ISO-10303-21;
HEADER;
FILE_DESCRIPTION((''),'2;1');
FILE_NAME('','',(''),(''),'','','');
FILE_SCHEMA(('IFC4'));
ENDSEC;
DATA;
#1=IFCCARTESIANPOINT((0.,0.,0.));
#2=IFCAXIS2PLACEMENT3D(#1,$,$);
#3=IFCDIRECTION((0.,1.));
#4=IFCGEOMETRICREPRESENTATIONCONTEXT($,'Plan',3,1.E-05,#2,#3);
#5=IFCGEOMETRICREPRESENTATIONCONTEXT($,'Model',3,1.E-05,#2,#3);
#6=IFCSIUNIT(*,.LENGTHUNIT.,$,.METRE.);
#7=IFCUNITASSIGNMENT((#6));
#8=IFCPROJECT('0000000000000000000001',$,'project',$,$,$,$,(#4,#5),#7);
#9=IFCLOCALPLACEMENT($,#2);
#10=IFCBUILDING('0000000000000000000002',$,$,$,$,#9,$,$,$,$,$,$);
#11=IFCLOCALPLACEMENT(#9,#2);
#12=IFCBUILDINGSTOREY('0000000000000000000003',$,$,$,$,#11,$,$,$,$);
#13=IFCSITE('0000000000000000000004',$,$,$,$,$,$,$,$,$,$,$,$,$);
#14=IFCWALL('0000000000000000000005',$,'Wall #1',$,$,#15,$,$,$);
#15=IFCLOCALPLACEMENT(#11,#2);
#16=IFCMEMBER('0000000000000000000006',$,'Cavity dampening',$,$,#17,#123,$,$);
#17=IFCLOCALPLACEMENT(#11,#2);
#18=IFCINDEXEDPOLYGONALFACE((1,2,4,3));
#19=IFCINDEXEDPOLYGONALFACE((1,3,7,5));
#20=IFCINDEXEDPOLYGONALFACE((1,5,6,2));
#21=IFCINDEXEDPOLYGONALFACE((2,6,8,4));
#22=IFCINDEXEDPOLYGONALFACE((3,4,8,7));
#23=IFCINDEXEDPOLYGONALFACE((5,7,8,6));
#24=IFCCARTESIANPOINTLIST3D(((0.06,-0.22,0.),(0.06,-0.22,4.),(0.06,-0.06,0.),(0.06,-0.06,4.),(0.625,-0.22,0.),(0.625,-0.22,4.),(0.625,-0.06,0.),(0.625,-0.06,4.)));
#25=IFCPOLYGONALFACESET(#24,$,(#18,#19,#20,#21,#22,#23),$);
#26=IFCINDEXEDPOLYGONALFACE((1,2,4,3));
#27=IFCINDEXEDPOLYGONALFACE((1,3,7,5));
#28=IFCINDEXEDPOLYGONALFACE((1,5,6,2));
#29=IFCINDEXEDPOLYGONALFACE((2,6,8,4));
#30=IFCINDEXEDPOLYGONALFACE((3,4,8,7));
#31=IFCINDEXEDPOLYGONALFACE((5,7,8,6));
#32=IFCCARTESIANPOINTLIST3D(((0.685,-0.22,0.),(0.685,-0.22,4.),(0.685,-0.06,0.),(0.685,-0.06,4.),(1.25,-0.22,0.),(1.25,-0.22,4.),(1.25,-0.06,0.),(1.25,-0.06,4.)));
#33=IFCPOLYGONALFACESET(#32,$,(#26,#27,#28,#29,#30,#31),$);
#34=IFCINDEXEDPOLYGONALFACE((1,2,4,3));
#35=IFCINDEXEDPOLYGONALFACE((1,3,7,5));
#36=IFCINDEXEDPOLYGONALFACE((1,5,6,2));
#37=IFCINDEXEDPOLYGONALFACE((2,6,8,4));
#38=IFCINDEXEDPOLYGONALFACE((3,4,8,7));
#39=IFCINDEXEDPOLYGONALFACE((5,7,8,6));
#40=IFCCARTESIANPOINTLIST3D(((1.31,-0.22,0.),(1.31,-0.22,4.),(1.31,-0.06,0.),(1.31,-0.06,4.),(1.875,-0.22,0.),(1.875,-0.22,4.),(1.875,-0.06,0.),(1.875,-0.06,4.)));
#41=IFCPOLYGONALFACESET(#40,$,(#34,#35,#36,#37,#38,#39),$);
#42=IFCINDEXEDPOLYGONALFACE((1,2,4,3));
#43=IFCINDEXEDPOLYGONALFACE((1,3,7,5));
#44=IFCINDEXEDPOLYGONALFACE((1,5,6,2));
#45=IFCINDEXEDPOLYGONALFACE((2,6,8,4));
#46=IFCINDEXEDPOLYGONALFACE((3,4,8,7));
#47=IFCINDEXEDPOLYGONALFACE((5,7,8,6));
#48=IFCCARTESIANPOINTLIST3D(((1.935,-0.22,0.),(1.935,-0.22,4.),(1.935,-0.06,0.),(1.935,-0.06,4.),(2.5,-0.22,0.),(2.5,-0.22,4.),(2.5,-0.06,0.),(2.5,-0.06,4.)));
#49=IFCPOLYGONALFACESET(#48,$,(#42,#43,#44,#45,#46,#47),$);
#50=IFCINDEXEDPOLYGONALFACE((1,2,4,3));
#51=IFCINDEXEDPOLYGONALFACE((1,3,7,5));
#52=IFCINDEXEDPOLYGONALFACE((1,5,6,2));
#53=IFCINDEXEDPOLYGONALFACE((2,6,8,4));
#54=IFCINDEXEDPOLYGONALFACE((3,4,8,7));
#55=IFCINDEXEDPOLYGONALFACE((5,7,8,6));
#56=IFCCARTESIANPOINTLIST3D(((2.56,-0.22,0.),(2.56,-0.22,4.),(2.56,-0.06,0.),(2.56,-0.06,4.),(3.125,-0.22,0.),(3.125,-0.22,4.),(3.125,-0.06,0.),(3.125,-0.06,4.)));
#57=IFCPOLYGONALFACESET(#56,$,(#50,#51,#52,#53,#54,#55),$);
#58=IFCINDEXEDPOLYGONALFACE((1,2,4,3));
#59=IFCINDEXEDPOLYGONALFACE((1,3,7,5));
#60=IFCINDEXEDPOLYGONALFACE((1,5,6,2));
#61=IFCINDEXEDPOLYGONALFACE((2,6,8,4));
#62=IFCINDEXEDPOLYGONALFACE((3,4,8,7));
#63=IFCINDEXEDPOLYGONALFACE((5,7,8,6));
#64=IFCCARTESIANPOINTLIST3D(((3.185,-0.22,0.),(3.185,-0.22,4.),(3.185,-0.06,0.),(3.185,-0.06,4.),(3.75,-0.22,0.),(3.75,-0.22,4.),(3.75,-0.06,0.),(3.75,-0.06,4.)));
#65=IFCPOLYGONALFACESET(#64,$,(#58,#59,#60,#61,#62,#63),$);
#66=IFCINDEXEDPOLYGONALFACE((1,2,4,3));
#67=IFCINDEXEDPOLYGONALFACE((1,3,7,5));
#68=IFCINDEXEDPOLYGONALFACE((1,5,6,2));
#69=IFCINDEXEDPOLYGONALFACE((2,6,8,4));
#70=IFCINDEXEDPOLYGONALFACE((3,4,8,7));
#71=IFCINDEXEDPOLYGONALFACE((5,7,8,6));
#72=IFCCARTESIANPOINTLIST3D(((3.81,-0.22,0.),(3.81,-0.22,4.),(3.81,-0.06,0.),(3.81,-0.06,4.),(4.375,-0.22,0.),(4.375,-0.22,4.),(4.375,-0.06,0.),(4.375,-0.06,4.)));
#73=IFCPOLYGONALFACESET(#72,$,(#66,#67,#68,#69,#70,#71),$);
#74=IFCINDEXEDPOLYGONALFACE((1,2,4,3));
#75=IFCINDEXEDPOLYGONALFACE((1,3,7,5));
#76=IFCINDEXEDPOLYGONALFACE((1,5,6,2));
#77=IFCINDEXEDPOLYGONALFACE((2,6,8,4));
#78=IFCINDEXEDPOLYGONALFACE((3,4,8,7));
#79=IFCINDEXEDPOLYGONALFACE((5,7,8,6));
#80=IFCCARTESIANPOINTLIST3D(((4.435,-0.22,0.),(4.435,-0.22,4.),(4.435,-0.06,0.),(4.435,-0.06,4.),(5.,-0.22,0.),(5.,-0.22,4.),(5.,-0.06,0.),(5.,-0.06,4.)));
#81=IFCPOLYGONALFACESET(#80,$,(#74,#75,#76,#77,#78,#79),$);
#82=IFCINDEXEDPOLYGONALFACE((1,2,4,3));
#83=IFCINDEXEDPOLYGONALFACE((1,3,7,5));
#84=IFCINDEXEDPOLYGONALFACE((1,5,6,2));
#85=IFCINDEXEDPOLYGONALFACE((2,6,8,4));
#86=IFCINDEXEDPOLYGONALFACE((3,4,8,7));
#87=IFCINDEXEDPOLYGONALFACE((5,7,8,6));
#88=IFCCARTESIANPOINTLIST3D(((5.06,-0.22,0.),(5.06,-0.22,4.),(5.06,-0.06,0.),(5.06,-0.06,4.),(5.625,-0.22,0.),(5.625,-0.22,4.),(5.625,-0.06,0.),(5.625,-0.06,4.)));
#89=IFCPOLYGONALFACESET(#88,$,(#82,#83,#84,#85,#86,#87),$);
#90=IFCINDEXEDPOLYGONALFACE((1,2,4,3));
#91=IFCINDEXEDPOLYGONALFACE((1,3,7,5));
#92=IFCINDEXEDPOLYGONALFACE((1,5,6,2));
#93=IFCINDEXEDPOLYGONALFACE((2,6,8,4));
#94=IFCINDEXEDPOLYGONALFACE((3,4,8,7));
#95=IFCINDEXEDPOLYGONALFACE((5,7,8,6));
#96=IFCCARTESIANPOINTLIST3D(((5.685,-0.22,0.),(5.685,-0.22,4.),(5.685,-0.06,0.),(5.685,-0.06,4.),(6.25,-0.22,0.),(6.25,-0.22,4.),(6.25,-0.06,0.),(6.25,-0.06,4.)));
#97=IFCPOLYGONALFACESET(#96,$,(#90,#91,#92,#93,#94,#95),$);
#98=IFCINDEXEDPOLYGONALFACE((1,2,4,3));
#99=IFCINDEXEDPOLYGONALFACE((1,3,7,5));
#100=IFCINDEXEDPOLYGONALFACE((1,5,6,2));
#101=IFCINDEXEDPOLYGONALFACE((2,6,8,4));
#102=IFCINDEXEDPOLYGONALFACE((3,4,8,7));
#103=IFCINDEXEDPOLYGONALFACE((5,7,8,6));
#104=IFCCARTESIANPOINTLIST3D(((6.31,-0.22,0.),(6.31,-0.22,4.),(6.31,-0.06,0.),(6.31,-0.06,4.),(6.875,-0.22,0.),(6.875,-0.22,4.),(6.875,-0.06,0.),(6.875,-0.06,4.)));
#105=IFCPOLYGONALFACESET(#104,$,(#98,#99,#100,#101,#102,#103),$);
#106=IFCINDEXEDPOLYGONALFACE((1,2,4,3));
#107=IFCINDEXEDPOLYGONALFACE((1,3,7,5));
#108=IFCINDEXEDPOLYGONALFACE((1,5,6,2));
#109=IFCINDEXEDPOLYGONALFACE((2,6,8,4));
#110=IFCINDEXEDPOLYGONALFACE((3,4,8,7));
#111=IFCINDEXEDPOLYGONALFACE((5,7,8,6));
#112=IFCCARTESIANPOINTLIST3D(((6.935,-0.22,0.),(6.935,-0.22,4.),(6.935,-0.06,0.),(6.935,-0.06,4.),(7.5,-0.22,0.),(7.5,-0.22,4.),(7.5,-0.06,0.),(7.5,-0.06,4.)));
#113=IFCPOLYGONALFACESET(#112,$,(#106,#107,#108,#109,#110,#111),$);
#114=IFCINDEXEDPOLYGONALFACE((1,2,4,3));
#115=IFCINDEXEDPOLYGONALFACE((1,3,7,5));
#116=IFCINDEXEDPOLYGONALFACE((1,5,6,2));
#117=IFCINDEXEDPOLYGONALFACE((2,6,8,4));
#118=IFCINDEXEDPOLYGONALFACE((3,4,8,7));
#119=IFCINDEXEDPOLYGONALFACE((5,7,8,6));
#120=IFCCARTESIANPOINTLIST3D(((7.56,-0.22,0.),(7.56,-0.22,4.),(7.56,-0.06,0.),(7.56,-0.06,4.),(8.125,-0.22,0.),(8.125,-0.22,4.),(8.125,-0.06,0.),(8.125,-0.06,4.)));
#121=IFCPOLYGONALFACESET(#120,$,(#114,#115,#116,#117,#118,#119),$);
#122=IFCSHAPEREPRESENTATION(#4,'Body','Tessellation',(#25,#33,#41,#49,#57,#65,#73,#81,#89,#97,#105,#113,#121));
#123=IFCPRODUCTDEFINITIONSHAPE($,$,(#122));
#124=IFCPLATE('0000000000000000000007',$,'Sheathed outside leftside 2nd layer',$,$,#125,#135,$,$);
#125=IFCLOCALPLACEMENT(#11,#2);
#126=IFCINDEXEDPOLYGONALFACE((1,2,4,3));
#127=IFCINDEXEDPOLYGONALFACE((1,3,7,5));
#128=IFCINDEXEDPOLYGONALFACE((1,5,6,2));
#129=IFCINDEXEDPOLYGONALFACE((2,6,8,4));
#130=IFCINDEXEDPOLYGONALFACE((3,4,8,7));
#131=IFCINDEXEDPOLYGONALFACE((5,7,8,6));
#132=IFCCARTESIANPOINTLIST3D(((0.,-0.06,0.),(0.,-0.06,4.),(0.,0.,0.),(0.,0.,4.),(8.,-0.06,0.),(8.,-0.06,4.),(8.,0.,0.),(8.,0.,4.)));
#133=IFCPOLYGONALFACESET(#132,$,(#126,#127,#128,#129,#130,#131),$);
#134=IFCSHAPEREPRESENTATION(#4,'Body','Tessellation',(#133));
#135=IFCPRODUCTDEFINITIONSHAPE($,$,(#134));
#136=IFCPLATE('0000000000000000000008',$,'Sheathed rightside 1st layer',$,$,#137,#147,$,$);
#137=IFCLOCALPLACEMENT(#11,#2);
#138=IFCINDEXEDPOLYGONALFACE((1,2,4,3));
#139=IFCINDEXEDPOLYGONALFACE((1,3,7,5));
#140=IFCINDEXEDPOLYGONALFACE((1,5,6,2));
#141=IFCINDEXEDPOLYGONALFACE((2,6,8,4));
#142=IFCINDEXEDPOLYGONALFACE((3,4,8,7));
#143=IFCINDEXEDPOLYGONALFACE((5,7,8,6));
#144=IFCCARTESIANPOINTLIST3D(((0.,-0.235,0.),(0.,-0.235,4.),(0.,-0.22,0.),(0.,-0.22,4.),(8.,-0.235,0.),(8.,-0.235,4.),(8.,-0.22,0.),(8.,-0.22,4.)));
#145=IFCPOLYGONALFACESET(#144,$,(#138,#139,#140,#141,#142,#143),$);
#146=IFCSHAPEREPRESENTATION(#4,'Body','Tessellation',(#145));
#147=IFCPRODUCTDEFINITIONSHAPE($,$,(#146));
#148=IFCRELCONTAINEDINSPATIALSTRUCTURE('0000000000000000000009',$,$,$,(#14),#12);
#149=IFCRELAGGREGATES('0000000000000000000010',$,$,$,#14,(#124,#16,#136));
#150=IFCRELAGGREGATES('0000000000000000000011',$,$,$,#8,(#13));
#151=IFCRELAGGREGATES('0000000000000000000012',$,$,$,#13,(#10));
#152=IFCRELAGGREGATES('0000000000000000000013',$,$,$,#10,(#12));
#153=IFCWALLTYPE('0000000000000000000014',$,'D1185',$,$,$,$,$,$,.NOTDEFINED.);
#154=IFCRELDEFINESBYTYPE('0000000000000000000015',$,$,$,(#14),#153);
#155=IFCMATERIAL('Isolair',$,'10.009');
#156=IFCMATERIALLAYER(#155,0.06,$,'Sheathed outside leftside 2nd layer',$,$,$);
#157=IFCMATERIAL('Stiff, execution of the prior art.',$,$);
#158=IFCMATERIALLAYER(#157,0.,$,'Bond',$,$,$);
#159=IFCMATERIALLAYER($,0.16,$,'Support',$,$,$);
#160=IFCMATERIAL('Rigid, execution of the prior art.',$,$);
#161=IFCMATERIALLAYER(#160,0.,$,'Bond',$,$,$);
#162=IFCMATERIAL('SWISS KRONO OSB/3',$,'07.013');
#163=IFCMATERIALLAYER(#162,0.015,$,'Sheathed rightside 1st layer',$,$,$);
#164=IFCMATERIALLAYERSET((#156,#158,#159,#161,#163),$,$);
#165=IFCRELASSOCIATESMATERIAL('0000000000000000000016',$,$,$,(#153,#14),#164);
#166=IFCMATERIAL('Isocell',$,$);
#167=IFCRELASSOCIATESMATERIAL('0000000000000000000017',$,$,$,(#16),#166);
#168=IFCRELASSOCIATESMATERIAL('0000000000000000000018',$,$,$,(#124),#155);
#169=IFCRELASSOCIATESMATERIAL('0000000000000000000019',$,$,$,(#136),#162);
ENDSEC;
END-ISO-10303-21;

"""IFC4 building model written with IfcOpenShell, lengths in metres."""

from ifc_helpers import new_model, si_unit, direction, frame, frame_2d, origin, origin_with_axes, place, context, project, spatial, rectangle, extrude, material, layer, layer_set, type_object, element, aggregate, save


model = new_model("IFC4")

# Units and contexts
plan_context = context("Plan", 3, precision=1e-05, world=origin(), true_north=direction((0.0, 1.0)))
model_context = context("Model", 3, precision=1e-05, world=origin(), true_north=direction((0.0, 1.0)))
ifc_project = project(units=[si_unit("LENGTHUNIT", "METRE")], contexts=[plan_context, model_context])

# Site, building, storey
site = spatial("IfcSite", under=ifc_project)
building_placement = place(None, origin())
building = spatial("IfcBuilding", under=site, at=building_placement)
storey_placement = place(building_placement, origin())
storey = spatial("IfcBuildingStorey", under=building, at=storey_placement)

# Wall, member, plates
ifc_material_1 = material(Name="Isolair", Category="10.009")
ifc_layer_1 = layer(ifc_material_1, 0.06, Name="Sheathed outside leftside 2nd layer")
ifc_material_2 = material(Name="Stiff, execution of the prior art.")
ifc_layer_2 = layer(ifc_material_2, 0.0, Name="Bond")
ifc_layer_3 = layer(None, 0.16, Name="Support")
ifc_material_3 = material(Name="Rigid, execution of the prior art.")
ifc_layer_4 = layer(ifc_material_3, 0.0, Name="Bond")
ifc_material_4 = material(Name="SWISS KRONO OSB/3", Category="07.013")
ifc_layer_5 = layer(ifc_material_4, 0.015, Name="Sheathed rightside 1st layer")
ifc_layer_set = layer_set([ifc_layer_1, ifc_layer_2, ifc_layer_3, ifc_layer_4, ifc_layer_5])
wall_type = type_object("IfcWallType", Name="D1185", PredefinedType="NOTDEFINED", material=ifc_layer_set)
wall_placement = place(None, frame((0.0, 0.0, 0.0), z_axis=(0.0, -1.0, 0.0), x_axis=(1.0, 0.0, 0.0)))
wall = element("IfcWall", 1, at=wall_placement, inside=storey, type_object=wall_type, material=ifc_layer_set, Name="Wall #1")
ifc_material_5 = material(Name="Isocell")
member_1_placement = place(wall_placement, origin())
member_1 = element("IfcMember", 2, at=member_1_placement, material=ifc_material_5, Name="Cavity dampening", context=plan_context, shape_type="SweptSolid", body=[
    extrude(rectangle(XDim=0.565, YDim=0.16, at=frame_2d((0.2825, 0.08), x_axis=(1.0, 0.0))), frame((0.06, 4.0, 0.06), z_axis=(0.0, -1.0, 0.0), x_axis=(1.0, 0.0, 0.0)), (0.0, 0.0, 1.0), 4.0),
    extrude(rectangle(XDim=0.565, YDim=0.16, at=frame_2d((0.2825, 0.08), x_axis=(1.0, 0.0))), frame((0.685, 4.0, 0.06), z_axis=(0.0, -1.0, 0.0), x_axis=(1.0, 0.0, 0.0)), (0.0, 0.0, 1.0), 4.0),
    extrude(rectangle(XDim=0.565, YDim=0.16, at=frame_2d((0.2825, 0.08), x_axis=(1.0, 0.0))), frame((1.31, 4.0, 0.06), z_axis=(0.0, -1.0, 0.0), x_axis=(1.0, 0.0, 0.0)), (0.0, 0.0, 1.0), 4.0),
    extrude(rectangle(XDim=0.565, YDim=0.16, at=frame_2d((0.2825, 0.08), x_axis=(1.0, 0.0))), frame((1.935, 4.0, 0.06), z_axis=(0.0, -1.0, 0.0), x_axis=(1.0, 0.0, 0.0)), (0.0, 0.0, 1.0), 4.0),
    extrude(rectangle(XDim=0.565, YDim=0.16, at=frame_2d((0.2825, 0.08), x_axis=(1.0, 0.0))), frame((2.56, 4.0, 0.06), z_axis=(0.0, -1.0, 0.0), x_axis=(1.0, 0.0, 0.0)), (0.0, 0.0, 1.0), 4.0),
    extrude(rectangle(XDim=0.565, YDim=0.16, at=frame_2d((0.2825, 0.08), x_axis=(1.0, 0.0))), frame((3.185, 4.0, 0.06), z_axis=(0.0, -1.0, 0.0), x_axis=(1.0, 0.0, 0.0)), (0.0, 0.0, 1.0), 4.0),
    extrude(rectangle(XDim=0.565, YDim=0.16, at=frame_2d((0.2825, 0.08), x_axis=(1.0, 0.0))), frame((3.81, 4.0, 0.06), z_axis=(0.0, -1.0, 0.0), x_axis=(1.0, 0.0, 0.0)), (0.0, 0.0, 1.0), 4.0),
    extrude(rectangle(XDim=0.565, YDim=0.16, at=frame_2d((0.2825, 0.08), x_axis=(1.0, 0.0))), frame((4.435, 4.0, 0.06), z_axis=(0.0, -1.0, 0.0), x_axis=(1.0, 0.0, 0.0)), (0.0, 0.0, 1.0), 4.0),
    extrude(rectangle(XDim=0.565, YDim=0.16, at=frame_2d((0.2825, 0.08), x_axis=(1.0, 0.0))), frame((5.06, 4.0, 0.06), z_axis=(0.0, -1.0, 0.0), x_axis=(1.0, 0.0, 0.0)), (0.0, 0.0, 1.0), 4.0),
    extrude(rectangle(XDim=0.565, YDim=0.16, at=frame_2d((0.2825, 0.08), x_axis=(1.0, 0.0))), frame((5.685, 4.0, 0.06), z_axis=(0.0, -1.0, 0.0), x_axis=(1.0, 0.0, 0.0)), (0.0, 0.0, 1.0), 4.0),
    extrude(rectangle(XDim=0.565, YDim=0.16, at=frame_2d((0.2825, 0.08), x_axis=(1.0, 0.0))), frame((6.31, 4.0, 0.06), z_axis=(0.0, -1.0, 0.0), x_axis=(1.0, 0.0, 0.0)), (0.0, 0.0, 1.0), 4.0),
    extrude(rectangle(XDim=0.565, YDim=0.16, at=frame_2d((0.2825, 0.08), x_axis=(1.0, 0.0))), frame((6.935, 4.0, 0.06), z_axis=(0.0, -1.0, 0.0), x_axis=(1.0, 0.0, 0.0)), (0.0, 0.0, 1.0), 4.0),
    extrude(rectangle(XDim=0.565, YDim=0.16, at=frame_2d((0.2825, 0.08), x_axis=(1.0, 0.0))), frame((7.56, 4.0, 0.06), z_axis=(0.0, -1.0, 0.0), x_axis=(1.0, 0.0, 0.0)), (0.0, 0.0, 1.0), 4.0),
])
plate_1_placement = place(wall_placement, origin())
plate_1 = element("IfcPlate", 3, at=plate_1_placement, material=ifc_material_1, Name="Sheathed outside leftside 2nd layer", context=plan_context, shape_type="SweptSolid", body=[
    extrude(rectangle(XDim=8.0, YDim=4.0, at=frame_2d((4.0, 2.0), x_axis=(1.0, 0.0))), origin_with_axes(), (0.0, 0.0, 1.0), 0.06),
])
plate_2_placement = place(wall_placement, origin())
plate_2 = element("IfcPlate", 4, at=plate_2_placement, material=ifc_material_4, Name="Sheathed rightside 1st layer", context=plan_context, shape_type="SweptSolid", body=[
    extrude(rectangle(XDim=8.0, YDim=4.0, at=frame_2d((4.0, 2.0), x_axis=(1.0, 0.0))), frame((0.0, 0.0, 0.22), z_axis=(0.0, 0.0, 1.0), x_axis=(1.0, 0.0, 0.0)), (0.0, 0.0, 1.0), 0.015),
])
aggregate(wall, [plate_1, member_1, plate_2])

save(model, "model.ifc")
